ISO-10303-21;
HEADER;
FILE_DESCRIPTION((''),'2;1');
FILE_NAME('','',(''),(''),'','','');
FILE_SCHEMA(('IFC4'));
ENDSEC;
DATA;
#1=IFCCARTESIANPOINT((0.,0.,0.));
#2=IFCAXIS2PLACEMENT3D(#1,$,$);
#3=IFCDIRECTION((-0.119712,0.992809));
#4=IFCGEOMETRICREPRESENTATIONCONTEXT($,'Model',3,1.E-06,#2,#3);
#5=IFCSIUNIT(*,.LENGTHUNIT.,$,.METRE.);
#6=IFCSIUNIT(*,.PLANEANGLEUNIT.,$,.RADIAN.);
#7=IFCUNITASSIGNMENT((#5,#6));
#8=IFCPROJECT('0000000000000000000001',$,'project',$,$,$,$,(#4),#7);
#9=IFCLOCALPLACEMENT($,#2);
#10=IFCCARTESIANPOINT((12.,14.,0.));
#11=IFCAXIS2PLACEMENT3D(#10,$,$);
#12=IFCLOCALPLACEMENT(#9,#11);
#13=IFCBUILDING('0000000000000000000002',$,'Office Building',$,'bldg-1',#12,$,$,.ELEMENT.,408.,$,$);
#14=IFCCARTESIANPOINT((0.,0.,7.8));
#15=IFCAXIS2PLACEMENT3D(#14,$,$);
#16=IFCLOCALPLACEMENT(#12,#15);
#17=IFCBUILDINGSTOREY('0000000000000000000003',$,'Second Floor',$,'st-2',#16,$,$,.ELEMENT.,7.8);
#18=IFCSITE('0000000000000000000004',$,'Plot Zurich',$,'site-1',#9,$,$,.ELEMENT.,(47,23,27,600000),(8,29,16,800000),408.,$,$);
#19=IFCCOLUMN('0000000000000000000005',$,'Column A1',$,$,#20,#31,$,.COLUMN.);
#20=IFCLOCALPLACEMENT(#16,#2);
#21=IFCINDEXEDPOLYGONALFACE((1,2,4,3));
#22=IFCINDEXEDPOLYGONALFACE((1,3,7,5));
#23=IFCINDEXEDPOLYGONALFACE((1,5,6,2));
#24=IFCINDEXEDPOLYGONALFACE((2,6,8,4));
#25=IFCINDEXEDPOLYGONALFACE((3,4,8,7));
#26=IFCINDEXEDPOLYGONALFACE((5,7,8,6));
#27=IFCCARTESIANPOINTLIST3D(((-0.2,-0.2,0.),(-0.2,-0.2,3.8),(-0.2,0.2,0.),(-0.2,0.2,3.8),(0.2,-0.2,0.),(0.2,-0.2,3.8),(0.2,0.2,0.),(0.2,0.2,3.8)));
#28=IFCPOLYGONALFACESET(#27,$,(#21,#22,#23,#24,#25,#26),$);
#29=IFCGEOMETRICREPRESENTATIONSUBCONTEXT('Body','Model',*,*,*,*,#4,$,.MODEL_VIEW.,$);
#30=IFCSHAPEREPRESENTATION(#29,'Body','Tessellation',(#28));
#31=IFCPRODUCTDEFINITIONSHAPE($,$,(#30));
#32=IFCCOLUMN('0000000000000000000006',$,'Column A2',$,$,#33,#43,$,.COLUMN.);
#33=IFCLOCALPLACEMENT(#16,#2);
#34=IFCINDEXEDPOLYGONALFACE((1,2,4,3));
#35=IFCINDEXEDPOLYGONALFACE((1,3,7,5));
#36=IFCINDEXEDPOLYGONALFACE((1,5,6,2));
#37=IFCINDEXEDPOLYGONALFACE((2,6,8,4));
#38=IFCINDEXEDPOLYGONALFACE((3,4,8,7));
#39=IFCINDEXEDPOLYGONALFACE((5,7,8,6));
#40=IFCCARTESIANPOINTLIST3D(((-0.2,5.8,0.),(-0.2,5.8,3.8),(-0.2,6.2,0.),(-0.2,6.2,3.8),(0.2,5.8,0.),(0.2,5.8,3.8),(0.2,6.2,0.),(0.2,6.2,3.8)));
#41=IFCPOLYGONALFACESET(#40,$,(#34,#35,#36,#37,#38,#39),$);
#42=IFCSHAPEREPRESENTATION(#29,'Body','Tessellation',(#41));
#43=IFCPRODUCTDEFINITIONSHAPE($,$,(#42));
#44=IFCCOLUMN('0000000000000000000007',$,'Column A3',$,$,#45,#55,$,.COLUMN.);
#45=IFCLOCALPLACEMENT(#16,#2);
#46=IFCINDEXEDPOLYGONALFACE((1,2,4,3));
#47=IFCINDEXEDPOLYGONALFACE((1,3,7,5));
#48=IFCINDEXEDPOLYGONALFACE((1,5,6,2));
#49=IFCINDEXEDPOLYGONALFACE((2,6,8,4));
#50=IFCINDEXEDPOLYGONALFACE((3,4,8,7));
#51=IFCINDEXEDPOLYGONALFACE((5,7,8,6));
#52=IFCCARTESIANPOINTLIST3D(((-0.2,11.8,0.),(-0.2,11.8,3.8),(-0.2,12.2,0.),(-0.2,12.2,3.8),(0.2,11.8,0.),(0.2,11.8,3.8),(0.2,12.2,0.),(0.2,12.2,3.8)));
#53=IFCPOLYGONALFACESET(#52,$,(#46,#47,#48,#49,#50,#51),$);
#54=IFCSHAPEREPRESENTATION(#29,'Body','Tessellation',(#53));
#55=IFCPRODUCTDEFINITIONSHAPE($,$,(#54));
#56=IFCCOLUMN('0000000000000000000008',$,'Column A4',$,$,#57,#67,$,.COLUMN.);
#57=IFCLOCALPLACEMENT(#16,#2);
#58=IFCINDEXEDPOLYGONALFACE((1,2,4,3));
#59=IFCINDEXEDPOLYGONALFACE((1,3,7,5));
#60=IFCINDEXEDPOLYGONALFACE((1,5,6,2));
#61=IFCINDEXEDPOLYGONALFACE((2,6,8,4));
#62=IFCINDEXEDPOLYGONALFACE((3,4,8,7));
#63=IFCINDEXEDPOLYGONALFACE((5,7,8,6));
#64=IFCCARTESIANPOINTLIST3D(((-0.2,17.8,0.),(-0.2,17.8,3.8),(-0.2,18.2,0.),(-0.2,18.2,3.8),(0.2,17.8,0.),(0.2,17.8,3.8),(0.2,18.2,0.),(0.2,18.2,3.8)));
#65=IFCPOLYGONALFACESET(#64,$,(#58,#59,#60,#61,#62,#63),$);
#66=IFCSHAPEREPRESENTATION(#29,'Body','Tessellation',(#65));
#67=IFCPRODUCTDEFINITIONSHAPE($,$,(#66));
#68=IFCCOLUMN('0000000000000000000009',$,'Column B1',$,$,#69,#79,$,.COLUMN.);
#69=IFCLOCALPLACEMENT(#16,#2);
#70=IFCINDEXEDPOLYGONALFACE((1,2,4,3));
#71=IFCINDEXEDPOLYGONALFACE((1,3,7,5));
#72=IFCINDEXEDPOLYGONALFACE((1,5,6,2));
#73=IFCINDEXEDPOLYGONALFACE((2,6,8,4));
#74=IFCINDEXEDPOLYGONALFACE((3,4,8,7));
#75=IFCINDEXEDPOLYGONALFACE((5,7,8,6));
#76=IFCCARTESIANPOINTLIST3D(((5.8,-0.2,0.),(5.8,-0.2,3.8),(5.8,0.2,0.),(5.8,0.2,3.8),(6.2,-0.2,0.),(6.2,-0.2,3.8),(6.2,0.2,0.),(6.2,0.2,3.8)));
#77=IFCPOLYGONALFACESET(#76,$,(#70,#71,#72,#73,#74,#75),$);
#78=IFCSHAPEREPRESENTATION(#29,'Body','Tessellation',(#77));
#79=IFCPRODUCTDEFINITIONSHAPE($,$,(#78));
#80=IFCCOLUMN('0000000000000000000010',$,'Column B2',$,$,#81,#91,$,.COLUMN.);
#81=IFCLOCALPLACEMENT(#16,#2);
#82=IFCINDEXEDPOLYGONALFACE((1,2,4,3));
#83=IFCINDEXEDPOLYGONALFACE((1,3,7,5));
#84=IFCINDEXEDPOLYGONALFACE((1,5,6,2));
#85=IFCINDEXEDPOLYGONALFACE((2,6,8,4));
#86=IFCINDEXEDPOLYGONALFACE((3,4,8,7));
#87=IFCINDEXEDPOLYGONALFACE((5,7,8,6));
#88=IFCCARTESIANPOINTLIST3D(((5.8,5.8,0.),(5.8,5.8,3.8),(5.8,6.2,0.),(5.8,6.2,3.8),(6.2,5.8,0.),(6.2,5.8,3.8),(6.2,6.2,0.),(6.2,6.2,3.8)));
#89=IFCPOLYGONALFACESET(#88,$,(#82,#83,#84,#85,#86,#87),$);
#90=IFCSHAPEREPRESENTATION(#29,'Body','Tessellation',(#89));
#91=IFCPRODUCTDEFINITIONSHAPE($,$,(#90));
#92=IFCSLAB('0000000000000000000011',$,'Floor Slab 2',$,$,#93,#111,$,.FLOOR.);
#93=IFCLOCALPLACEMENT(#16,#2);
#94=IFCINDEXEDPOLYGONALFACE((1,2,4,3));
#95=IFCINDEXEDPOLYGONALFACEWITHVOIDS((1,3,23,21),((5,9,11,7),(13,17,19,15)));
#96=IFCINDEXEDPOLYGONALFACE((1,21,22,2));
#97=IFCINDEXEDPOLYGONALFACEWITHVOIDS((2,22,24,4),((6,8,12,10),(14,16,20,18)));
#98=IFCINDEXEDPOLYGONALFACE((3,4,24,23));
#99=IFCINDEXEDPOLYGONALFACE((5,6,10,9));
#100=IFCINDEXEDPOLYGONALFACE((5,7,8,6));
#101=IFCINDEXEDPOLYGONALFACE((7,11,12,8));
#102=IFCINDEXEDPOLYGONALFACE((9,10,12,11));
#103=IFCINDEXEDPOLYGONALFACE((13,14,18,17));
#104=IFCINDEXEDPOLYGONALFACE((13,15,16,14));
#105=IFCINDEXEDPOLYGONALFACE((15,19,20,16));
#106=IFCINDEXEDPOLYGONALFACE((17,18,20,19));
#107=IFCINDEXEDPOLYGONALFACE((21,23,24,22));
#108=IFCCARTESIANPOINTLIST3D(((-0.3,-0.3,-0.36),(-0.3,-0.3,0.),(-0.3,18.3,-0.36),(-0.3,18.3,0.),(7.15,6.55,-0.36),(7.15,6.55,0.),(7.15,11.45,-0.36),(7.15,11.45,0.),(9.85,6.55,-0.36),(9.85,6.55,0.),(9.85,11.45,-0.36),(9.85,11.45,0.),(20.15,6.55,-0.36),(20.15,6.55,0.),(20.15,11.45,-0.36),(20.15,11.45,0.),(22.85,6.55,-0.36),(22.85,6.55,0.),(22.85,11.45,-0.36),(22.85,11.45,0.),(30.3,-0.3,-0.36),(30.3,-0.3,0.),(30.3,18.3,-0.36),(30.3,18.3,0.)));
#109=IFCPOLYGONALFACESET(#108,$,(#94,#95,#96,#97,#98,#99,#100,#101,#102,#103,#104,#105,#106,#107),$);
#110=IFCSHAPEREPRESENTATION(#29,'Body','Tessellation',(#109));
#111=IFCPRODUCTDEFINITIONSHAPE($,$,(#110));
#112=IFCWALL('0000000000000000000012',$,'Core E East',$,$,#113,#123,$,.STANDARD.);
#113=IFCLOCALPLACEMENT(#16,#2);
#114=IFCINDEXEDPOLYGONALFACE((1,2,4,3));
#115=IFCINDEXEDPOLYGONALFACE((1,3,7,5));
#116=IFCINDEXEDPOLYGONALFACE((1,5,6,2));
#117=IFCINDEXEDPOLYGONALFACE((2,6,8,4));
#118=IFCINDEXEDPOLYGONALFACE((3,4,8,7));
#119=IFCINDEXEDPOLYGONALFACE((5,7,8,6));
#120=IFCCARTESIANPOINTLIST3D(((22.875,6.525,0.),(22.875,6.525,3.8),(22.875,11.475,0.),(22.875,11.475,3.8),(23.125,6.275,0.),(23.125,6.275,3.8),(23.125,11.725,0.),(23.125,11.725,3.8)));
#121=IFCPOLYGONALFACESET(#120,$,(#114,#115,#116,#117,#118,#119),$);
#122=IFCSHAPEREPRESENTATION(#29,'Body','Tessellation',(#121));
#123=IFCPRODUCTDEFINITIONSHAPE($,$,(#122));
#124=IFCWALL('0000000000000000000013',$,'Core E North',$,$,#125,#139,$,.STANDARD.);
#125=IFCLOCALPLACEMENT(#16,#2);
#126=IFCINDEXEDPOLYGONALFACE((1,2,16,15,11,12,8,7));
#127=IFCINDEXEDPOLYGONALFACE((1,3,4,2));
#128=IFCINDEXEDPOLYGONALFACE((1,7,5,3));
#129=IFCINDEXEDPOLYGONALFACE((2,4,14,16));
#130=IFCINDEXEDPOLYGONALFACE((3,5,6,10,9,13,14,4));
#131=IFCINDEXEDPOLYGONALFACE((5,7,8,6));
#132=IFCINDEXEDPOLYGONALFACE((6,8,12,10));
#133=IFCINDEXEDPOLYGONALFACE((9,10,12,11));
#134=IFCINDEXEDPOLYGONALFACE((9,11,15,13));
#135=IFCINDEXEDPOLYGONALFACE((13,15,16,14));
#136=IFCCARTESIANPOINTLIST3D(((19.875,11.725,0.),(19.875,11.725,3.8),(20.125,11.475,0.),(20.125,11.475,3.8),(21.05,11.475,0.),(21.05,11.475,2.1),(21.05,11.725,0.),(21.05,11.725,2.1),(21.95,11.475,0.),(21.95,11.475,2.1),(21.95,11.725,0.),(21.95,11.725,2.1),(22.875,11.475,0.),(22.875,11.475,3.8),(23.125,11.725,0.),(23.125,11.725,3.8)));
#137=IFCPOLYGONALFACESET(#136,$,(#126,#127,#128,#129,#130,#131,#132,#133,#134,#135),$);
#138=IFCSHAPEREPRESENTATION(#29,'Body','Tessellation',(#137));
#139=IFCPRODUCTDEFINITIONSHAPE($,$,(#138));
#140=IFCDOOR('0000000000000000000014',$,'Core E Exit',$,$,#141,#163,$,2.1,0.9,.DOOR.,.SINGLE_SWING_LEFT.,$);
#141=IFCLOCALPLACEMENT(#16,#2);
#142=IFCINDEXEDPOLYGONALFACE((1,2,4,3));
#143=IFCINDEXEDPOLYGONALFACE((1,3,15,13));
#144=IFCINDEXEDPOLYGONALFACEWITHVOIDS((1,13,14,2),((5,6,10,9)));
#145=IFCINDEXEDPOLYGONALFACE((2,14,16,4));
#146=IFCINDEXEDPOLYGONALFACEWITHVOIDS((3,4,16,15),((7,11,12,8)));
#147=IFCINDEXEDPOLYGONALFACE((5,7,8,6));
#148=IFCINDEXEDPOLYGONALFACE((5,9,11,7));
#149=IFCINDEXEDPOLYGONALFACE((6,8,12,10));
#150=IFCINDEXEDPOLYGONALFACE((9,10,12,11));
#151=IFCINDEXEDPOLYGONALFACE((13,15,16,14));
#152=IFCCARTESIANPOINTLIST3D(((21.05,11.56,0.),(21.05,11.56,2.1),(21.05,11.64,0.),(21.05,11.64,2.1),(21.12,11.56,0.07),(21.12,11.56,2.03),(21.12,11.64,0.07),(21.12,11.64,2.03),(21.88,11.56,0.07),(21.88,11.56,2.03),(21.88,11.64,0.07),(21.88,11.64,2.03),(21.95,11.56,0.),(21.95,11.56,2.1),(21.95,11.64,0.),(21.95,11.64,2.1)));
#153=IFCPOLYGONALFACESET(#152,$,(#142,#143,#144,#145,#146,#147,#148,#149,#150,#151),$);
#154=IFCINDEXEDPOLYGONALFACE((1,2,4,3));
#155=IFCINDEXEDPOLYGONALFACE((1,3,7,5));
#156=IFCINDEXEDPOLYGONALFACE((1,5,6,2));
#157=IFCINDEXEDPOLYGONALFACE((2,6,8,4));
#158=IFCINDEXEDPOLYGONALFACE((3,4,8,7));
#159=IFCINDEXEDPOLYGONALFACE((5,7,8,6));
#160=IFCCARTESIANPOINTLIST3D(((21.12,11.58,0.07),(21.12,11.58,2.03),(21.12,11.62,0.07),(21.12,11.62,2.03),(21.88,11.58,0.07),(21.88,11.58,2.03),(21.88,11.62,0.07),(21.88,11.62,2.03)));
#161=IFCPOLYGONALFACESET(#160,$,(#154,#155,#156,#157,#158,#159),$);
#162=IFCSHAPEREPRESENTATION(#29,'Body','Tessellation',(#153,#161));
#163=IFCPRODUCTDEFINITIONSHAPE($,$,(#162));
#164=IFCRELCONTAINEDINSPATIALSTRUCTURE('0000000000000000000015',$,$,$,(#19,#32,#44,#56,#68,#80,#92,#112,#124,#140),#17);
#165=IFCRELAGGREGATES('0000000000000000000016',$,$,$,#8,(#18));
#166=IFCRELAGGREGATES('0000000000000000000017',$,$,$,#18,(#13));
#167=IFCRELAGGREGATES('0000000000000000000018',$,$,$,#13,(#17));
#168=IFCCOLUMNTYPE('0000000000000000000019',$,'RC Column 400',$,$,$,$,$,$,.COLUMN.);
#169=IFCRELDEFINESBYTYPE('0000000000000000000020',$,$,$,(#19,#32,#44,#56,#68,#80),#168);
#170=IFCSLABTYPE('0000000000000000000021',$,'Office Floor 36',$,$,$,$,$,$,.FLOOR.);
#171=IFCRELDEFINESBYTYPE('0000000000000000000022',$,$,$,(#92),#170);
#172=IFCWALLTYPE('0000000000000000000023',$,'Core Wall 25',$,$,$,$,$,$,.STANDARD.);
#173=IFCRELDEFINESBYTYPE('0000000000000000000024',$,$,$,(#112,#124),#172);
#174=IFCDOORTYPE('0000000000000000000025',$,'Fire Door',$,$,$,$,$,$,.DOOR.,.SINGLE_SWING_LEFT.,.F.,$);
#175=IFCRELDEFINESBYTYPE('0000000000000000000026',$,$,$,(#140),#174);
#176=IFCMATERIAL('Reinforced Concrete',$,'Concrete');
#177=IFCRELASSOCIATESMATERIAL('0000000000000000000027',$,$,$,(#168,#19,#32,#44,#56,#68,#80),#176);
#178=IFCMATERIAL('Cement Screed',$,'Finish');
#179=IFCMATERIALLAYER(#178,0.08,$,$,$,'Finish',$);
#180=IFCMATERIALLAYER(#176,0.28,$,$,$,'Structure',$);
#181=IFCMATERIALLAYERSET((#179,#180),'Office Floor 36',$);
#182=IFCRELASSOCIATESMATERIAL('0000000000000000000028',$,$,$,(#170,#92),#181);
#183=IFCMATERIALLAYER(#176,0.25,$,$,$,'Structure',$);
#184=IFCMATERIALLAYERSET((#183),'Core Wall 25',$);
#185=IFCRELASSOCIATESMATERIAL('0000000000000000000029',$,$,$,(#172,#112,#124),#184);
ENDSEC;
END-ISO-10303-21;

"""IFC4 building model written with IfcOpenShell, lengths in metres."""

from ifc_helpers import new_model, si_unit, direction, frame, frame_2d, origin, origin_2d, place, context, subcontext, project, spatial, polyline, rectangle, outline, extrude, material, layer, layer_set, layer_usage, type_object, element, fill, save


model = new_model("IFC4")

# Units and contexts
model_context = context("Model", 3, precision=1e-06, world=origin(), true_north=direction((-0.119712, 0.992809)))
body_context = subcontext(model_context, "Body", "Model", "MODEL_VIEW")
ifc_project = project(units=[si_unit("LENGTHUNIT", "METRE"), si_unit("PLANEANGLEUNIT", "RADIAN")], contexts=[model_context])

# Site, building, storey
site_placement = place(None, origin())
site = spatial("IfcSite", under=ifc_project, at=site_placement, Name="Plot Zurich", ObjectType="site-1", CompositionType="ELEMENT", RefLatitude=(47, 23, 27, 600000), RefLongitude=(8, 29, 16, 800000), RefElevation=408.0)
building_placement = place(site_placement, frame((12.0, 14.0, 0.0)))
building = spatial("IfcBuilding", under=site, at=building_placement, Name="Office Building", ObjectType="bldg-1", CompositionType="ELEMENT", ElevationOfRefHeight=408.0)
storey_placement = place(building_placement, frame((0.0, 0.0, 7.8)))
storey = spatial("IfcBuildingStorey", under=building, at=storey_placement, Name="Second Floor", ObjectType="st-2", CompositionType="ELEMENT", Elevation=7.8)

# Columns
ifc_material_1 = material(Name="Reinforced Concrete", Category="Concrete")
column_type = type_object("IfcColumnType", Name="RC Column 400", PredefinedType="COLUMN", material=ifc_material_1)
for number, where, name in (
    (1, (0.0, 0.0, 0.0), "Column A1"),
    (2, (0.0, 6.0, 0.0), "Column A2"),
    (3, (0.0, 12.0, 0.0), "Column A3"),
    (4, (0.0, 18.0, 0.0), "Column A4"),
    (5, (6.0, 0.0, 0.0), "Column B1"),
    (6, (6.0, 6.0, 0.0), "Column B2"),
):
    element("IfcColumn", number, at=place(storey_placement, frame(where)), inside=storey, type_object=column_type, material=ifc_material_1, Name=name, PredefinedType="COLUMN", context=body_context, shape_type="SweptSolid", body=[
        extrude(rectangle(XDim=0.4, YDim=0.4, at=origin_2d()), origin(), (0.0, 0.0, 1.0), 3.8),
    ])

# Slab
ifc_material_2 = material(Name="Cement Screed", Category="Finish")
ifc_layer_1 = layer(ifc_material_2, 0.08, Category="Finish")
ifc_layer_2 = layer(ifc_material_1, 0.28, Category="Structure")
ifc_layer_set_1 = layer_set([ifc_layer_1, ifc_layer_2], Name="Office Floor 36")
ifc_layer_usage_1 = layer_usage(ifc_layer_set_1, "AXIS3", "NEGATIVE", 0.36)
slab_type = type_object("IfcSlabType", Name="Office Floor 36", PredefinedType="FLOOR", material=ifc_layer_set_1)
slab_placement = place(storey_placement, frame((0.0, 0.0, -0.36)))
element("IfcSlab", 7, at=slab_placement, inside=storey, type_object=slab_type, material=ifc_layer_usage_1, Name="Floor Slab 2", PredefinedType="FLOOR", context=body_context, shape_type="SweptSolid", body=[
    extrude(outline(polyline([(-0.3, -0.3), (30.3, -0.3), (30.3, 18.3), (-0.3, 18.3), (-0.3, -0.3)]), holes=[polyline([(7.15, 6.55), (7.15, 11.45), (9.85, 11.45), (9.85, 6.55), (7.15, 6.55)]), polyline([(20.15, 6.55), (20.15, 11.45), (22.85, 11.45), (22.85, 6.55), (20.15, 6.55)])]), origin(), (0.0, 0.0, 1.0), 0.36),
])

# Wall
ifc_layer_3 = layer(ifc_material_1, 0.25, Category="Structure")
ifc_layer_set_2 = layer_set([ifc_layer_3], Name="Core Wall 25")
ifc_layer_usage_2 = layer_usage(ifc_layer_set_2, "AXIS2", "NEGATIVE", 0.125)
wall_type_1 = type_object("IfcWallType", Name="Core Wall 25", PredefinedType="STANDARD", material=ifc_layer_set_2)
wall_1_placement = place(storey_placement, origin())
element("IfcWall", 8, at=wall_1_placement, inside=storey, type_object=wall_type_1, material=ifc_layer_usage_2, Name="Core E East", PredefinedType="STANDARD", context=body_context, shape_type="SweptSolid", body=[
    extrude(outline(polyline([(23.125, 6.275), (23.125, 11.725), (22.875, 11.475), (22.875, 6.525), (23.125, 6.275)])), origin(), (0.0, 0.0, 1.0), 3.8),
])

# Wall, opening, door
ifc_layer_usage_3 = layer_usage(ifc_layer_set_2, "AXIS2", "NEGATIVE", 0.125)
wall_2_placement = place(storey_placement, origin())
wall_2 = element("IfcWall", 9, at=wall_2_placement, inside=storey, type_object=wall_type_1, material=ifc_layer_usage_3, Name="Core E North", PredefinedType="STANDARD", context=body_context, shape_type="SweptSolid", body=[
    extrude(outline(polyline([(23.125, 11.725), (19.875, 11.725), (20.125, 11.475), (22.875, 11.475), (23.125, 11.725)])), origin(), (0.0, 0.0, 1.0), 3.8),
])
opening_1_placement = place(wall_2_placement, frame((21.5, 11.6, 0.0), z_axis=(0.0, 0.0, 1.0), x_axis=(-1.0, 0.0, 0.0)))
opening_1 = element("IfcOpeningElement", 10, at=opening_1_placement, cuts=wall_2, PredefinedType="OPENING", context=body_context, shape_type="SweptSolid", body=[
    extrude(rectangle(XDim=0.9, YDim=0.25, at=origin_2d()), origin(), (0.0, 0.0, 1.0), 2.1),
])
door_type = type_object("IfcDoorType", Name="Fire Door", OperationType="SINGLE_SWING_LEFT", ParameterTakesPrecedence=False, PredefinedType="DOOR")
door_1_placement = place(opening_1_placement, frame((0.0, 0.0, 0.0), z_axis=(0.0, -1.0, 0.0), x_axis=(1.0, 0.0, 0.0)))
door_1 = element("IfcDoor", 11, at=door_1_placement, inside=storey, type_object=door_type, Name="Core E Exit", OperationType="SINGLE_SWING_LEFT", OverallHeight=2.1, OverallWidth=0.9, PredefinedType="DOOR", context=body_context, shape_type="SweptSolid", body=[
    extrude(outline(polyline([(-0.45, 0.0), (0.45, 0.0), (0.45, 2.1), (-0.45, 2.1), (-0.45, 0.0)]), holes=[polyline([(-0.38, 0.07), (0.38, 0.07), (0.38, 2.03), (-0.38, 2.03), (-0.38, 0.07)])]), frame((0.0, 0.0, -0.04)), (0.0, 0.0, 1.0), 0.08),
    extrude(rectangle(XDim=0.76, YDim=1.96, at=frame_2d((0.0, 1.05))), frame((0.0, 0.0, -0.02)), (0.0, 0.0, 1.0), 0.04),
])
fill(opening_1, door_1)

save(model, "model.ifc")
